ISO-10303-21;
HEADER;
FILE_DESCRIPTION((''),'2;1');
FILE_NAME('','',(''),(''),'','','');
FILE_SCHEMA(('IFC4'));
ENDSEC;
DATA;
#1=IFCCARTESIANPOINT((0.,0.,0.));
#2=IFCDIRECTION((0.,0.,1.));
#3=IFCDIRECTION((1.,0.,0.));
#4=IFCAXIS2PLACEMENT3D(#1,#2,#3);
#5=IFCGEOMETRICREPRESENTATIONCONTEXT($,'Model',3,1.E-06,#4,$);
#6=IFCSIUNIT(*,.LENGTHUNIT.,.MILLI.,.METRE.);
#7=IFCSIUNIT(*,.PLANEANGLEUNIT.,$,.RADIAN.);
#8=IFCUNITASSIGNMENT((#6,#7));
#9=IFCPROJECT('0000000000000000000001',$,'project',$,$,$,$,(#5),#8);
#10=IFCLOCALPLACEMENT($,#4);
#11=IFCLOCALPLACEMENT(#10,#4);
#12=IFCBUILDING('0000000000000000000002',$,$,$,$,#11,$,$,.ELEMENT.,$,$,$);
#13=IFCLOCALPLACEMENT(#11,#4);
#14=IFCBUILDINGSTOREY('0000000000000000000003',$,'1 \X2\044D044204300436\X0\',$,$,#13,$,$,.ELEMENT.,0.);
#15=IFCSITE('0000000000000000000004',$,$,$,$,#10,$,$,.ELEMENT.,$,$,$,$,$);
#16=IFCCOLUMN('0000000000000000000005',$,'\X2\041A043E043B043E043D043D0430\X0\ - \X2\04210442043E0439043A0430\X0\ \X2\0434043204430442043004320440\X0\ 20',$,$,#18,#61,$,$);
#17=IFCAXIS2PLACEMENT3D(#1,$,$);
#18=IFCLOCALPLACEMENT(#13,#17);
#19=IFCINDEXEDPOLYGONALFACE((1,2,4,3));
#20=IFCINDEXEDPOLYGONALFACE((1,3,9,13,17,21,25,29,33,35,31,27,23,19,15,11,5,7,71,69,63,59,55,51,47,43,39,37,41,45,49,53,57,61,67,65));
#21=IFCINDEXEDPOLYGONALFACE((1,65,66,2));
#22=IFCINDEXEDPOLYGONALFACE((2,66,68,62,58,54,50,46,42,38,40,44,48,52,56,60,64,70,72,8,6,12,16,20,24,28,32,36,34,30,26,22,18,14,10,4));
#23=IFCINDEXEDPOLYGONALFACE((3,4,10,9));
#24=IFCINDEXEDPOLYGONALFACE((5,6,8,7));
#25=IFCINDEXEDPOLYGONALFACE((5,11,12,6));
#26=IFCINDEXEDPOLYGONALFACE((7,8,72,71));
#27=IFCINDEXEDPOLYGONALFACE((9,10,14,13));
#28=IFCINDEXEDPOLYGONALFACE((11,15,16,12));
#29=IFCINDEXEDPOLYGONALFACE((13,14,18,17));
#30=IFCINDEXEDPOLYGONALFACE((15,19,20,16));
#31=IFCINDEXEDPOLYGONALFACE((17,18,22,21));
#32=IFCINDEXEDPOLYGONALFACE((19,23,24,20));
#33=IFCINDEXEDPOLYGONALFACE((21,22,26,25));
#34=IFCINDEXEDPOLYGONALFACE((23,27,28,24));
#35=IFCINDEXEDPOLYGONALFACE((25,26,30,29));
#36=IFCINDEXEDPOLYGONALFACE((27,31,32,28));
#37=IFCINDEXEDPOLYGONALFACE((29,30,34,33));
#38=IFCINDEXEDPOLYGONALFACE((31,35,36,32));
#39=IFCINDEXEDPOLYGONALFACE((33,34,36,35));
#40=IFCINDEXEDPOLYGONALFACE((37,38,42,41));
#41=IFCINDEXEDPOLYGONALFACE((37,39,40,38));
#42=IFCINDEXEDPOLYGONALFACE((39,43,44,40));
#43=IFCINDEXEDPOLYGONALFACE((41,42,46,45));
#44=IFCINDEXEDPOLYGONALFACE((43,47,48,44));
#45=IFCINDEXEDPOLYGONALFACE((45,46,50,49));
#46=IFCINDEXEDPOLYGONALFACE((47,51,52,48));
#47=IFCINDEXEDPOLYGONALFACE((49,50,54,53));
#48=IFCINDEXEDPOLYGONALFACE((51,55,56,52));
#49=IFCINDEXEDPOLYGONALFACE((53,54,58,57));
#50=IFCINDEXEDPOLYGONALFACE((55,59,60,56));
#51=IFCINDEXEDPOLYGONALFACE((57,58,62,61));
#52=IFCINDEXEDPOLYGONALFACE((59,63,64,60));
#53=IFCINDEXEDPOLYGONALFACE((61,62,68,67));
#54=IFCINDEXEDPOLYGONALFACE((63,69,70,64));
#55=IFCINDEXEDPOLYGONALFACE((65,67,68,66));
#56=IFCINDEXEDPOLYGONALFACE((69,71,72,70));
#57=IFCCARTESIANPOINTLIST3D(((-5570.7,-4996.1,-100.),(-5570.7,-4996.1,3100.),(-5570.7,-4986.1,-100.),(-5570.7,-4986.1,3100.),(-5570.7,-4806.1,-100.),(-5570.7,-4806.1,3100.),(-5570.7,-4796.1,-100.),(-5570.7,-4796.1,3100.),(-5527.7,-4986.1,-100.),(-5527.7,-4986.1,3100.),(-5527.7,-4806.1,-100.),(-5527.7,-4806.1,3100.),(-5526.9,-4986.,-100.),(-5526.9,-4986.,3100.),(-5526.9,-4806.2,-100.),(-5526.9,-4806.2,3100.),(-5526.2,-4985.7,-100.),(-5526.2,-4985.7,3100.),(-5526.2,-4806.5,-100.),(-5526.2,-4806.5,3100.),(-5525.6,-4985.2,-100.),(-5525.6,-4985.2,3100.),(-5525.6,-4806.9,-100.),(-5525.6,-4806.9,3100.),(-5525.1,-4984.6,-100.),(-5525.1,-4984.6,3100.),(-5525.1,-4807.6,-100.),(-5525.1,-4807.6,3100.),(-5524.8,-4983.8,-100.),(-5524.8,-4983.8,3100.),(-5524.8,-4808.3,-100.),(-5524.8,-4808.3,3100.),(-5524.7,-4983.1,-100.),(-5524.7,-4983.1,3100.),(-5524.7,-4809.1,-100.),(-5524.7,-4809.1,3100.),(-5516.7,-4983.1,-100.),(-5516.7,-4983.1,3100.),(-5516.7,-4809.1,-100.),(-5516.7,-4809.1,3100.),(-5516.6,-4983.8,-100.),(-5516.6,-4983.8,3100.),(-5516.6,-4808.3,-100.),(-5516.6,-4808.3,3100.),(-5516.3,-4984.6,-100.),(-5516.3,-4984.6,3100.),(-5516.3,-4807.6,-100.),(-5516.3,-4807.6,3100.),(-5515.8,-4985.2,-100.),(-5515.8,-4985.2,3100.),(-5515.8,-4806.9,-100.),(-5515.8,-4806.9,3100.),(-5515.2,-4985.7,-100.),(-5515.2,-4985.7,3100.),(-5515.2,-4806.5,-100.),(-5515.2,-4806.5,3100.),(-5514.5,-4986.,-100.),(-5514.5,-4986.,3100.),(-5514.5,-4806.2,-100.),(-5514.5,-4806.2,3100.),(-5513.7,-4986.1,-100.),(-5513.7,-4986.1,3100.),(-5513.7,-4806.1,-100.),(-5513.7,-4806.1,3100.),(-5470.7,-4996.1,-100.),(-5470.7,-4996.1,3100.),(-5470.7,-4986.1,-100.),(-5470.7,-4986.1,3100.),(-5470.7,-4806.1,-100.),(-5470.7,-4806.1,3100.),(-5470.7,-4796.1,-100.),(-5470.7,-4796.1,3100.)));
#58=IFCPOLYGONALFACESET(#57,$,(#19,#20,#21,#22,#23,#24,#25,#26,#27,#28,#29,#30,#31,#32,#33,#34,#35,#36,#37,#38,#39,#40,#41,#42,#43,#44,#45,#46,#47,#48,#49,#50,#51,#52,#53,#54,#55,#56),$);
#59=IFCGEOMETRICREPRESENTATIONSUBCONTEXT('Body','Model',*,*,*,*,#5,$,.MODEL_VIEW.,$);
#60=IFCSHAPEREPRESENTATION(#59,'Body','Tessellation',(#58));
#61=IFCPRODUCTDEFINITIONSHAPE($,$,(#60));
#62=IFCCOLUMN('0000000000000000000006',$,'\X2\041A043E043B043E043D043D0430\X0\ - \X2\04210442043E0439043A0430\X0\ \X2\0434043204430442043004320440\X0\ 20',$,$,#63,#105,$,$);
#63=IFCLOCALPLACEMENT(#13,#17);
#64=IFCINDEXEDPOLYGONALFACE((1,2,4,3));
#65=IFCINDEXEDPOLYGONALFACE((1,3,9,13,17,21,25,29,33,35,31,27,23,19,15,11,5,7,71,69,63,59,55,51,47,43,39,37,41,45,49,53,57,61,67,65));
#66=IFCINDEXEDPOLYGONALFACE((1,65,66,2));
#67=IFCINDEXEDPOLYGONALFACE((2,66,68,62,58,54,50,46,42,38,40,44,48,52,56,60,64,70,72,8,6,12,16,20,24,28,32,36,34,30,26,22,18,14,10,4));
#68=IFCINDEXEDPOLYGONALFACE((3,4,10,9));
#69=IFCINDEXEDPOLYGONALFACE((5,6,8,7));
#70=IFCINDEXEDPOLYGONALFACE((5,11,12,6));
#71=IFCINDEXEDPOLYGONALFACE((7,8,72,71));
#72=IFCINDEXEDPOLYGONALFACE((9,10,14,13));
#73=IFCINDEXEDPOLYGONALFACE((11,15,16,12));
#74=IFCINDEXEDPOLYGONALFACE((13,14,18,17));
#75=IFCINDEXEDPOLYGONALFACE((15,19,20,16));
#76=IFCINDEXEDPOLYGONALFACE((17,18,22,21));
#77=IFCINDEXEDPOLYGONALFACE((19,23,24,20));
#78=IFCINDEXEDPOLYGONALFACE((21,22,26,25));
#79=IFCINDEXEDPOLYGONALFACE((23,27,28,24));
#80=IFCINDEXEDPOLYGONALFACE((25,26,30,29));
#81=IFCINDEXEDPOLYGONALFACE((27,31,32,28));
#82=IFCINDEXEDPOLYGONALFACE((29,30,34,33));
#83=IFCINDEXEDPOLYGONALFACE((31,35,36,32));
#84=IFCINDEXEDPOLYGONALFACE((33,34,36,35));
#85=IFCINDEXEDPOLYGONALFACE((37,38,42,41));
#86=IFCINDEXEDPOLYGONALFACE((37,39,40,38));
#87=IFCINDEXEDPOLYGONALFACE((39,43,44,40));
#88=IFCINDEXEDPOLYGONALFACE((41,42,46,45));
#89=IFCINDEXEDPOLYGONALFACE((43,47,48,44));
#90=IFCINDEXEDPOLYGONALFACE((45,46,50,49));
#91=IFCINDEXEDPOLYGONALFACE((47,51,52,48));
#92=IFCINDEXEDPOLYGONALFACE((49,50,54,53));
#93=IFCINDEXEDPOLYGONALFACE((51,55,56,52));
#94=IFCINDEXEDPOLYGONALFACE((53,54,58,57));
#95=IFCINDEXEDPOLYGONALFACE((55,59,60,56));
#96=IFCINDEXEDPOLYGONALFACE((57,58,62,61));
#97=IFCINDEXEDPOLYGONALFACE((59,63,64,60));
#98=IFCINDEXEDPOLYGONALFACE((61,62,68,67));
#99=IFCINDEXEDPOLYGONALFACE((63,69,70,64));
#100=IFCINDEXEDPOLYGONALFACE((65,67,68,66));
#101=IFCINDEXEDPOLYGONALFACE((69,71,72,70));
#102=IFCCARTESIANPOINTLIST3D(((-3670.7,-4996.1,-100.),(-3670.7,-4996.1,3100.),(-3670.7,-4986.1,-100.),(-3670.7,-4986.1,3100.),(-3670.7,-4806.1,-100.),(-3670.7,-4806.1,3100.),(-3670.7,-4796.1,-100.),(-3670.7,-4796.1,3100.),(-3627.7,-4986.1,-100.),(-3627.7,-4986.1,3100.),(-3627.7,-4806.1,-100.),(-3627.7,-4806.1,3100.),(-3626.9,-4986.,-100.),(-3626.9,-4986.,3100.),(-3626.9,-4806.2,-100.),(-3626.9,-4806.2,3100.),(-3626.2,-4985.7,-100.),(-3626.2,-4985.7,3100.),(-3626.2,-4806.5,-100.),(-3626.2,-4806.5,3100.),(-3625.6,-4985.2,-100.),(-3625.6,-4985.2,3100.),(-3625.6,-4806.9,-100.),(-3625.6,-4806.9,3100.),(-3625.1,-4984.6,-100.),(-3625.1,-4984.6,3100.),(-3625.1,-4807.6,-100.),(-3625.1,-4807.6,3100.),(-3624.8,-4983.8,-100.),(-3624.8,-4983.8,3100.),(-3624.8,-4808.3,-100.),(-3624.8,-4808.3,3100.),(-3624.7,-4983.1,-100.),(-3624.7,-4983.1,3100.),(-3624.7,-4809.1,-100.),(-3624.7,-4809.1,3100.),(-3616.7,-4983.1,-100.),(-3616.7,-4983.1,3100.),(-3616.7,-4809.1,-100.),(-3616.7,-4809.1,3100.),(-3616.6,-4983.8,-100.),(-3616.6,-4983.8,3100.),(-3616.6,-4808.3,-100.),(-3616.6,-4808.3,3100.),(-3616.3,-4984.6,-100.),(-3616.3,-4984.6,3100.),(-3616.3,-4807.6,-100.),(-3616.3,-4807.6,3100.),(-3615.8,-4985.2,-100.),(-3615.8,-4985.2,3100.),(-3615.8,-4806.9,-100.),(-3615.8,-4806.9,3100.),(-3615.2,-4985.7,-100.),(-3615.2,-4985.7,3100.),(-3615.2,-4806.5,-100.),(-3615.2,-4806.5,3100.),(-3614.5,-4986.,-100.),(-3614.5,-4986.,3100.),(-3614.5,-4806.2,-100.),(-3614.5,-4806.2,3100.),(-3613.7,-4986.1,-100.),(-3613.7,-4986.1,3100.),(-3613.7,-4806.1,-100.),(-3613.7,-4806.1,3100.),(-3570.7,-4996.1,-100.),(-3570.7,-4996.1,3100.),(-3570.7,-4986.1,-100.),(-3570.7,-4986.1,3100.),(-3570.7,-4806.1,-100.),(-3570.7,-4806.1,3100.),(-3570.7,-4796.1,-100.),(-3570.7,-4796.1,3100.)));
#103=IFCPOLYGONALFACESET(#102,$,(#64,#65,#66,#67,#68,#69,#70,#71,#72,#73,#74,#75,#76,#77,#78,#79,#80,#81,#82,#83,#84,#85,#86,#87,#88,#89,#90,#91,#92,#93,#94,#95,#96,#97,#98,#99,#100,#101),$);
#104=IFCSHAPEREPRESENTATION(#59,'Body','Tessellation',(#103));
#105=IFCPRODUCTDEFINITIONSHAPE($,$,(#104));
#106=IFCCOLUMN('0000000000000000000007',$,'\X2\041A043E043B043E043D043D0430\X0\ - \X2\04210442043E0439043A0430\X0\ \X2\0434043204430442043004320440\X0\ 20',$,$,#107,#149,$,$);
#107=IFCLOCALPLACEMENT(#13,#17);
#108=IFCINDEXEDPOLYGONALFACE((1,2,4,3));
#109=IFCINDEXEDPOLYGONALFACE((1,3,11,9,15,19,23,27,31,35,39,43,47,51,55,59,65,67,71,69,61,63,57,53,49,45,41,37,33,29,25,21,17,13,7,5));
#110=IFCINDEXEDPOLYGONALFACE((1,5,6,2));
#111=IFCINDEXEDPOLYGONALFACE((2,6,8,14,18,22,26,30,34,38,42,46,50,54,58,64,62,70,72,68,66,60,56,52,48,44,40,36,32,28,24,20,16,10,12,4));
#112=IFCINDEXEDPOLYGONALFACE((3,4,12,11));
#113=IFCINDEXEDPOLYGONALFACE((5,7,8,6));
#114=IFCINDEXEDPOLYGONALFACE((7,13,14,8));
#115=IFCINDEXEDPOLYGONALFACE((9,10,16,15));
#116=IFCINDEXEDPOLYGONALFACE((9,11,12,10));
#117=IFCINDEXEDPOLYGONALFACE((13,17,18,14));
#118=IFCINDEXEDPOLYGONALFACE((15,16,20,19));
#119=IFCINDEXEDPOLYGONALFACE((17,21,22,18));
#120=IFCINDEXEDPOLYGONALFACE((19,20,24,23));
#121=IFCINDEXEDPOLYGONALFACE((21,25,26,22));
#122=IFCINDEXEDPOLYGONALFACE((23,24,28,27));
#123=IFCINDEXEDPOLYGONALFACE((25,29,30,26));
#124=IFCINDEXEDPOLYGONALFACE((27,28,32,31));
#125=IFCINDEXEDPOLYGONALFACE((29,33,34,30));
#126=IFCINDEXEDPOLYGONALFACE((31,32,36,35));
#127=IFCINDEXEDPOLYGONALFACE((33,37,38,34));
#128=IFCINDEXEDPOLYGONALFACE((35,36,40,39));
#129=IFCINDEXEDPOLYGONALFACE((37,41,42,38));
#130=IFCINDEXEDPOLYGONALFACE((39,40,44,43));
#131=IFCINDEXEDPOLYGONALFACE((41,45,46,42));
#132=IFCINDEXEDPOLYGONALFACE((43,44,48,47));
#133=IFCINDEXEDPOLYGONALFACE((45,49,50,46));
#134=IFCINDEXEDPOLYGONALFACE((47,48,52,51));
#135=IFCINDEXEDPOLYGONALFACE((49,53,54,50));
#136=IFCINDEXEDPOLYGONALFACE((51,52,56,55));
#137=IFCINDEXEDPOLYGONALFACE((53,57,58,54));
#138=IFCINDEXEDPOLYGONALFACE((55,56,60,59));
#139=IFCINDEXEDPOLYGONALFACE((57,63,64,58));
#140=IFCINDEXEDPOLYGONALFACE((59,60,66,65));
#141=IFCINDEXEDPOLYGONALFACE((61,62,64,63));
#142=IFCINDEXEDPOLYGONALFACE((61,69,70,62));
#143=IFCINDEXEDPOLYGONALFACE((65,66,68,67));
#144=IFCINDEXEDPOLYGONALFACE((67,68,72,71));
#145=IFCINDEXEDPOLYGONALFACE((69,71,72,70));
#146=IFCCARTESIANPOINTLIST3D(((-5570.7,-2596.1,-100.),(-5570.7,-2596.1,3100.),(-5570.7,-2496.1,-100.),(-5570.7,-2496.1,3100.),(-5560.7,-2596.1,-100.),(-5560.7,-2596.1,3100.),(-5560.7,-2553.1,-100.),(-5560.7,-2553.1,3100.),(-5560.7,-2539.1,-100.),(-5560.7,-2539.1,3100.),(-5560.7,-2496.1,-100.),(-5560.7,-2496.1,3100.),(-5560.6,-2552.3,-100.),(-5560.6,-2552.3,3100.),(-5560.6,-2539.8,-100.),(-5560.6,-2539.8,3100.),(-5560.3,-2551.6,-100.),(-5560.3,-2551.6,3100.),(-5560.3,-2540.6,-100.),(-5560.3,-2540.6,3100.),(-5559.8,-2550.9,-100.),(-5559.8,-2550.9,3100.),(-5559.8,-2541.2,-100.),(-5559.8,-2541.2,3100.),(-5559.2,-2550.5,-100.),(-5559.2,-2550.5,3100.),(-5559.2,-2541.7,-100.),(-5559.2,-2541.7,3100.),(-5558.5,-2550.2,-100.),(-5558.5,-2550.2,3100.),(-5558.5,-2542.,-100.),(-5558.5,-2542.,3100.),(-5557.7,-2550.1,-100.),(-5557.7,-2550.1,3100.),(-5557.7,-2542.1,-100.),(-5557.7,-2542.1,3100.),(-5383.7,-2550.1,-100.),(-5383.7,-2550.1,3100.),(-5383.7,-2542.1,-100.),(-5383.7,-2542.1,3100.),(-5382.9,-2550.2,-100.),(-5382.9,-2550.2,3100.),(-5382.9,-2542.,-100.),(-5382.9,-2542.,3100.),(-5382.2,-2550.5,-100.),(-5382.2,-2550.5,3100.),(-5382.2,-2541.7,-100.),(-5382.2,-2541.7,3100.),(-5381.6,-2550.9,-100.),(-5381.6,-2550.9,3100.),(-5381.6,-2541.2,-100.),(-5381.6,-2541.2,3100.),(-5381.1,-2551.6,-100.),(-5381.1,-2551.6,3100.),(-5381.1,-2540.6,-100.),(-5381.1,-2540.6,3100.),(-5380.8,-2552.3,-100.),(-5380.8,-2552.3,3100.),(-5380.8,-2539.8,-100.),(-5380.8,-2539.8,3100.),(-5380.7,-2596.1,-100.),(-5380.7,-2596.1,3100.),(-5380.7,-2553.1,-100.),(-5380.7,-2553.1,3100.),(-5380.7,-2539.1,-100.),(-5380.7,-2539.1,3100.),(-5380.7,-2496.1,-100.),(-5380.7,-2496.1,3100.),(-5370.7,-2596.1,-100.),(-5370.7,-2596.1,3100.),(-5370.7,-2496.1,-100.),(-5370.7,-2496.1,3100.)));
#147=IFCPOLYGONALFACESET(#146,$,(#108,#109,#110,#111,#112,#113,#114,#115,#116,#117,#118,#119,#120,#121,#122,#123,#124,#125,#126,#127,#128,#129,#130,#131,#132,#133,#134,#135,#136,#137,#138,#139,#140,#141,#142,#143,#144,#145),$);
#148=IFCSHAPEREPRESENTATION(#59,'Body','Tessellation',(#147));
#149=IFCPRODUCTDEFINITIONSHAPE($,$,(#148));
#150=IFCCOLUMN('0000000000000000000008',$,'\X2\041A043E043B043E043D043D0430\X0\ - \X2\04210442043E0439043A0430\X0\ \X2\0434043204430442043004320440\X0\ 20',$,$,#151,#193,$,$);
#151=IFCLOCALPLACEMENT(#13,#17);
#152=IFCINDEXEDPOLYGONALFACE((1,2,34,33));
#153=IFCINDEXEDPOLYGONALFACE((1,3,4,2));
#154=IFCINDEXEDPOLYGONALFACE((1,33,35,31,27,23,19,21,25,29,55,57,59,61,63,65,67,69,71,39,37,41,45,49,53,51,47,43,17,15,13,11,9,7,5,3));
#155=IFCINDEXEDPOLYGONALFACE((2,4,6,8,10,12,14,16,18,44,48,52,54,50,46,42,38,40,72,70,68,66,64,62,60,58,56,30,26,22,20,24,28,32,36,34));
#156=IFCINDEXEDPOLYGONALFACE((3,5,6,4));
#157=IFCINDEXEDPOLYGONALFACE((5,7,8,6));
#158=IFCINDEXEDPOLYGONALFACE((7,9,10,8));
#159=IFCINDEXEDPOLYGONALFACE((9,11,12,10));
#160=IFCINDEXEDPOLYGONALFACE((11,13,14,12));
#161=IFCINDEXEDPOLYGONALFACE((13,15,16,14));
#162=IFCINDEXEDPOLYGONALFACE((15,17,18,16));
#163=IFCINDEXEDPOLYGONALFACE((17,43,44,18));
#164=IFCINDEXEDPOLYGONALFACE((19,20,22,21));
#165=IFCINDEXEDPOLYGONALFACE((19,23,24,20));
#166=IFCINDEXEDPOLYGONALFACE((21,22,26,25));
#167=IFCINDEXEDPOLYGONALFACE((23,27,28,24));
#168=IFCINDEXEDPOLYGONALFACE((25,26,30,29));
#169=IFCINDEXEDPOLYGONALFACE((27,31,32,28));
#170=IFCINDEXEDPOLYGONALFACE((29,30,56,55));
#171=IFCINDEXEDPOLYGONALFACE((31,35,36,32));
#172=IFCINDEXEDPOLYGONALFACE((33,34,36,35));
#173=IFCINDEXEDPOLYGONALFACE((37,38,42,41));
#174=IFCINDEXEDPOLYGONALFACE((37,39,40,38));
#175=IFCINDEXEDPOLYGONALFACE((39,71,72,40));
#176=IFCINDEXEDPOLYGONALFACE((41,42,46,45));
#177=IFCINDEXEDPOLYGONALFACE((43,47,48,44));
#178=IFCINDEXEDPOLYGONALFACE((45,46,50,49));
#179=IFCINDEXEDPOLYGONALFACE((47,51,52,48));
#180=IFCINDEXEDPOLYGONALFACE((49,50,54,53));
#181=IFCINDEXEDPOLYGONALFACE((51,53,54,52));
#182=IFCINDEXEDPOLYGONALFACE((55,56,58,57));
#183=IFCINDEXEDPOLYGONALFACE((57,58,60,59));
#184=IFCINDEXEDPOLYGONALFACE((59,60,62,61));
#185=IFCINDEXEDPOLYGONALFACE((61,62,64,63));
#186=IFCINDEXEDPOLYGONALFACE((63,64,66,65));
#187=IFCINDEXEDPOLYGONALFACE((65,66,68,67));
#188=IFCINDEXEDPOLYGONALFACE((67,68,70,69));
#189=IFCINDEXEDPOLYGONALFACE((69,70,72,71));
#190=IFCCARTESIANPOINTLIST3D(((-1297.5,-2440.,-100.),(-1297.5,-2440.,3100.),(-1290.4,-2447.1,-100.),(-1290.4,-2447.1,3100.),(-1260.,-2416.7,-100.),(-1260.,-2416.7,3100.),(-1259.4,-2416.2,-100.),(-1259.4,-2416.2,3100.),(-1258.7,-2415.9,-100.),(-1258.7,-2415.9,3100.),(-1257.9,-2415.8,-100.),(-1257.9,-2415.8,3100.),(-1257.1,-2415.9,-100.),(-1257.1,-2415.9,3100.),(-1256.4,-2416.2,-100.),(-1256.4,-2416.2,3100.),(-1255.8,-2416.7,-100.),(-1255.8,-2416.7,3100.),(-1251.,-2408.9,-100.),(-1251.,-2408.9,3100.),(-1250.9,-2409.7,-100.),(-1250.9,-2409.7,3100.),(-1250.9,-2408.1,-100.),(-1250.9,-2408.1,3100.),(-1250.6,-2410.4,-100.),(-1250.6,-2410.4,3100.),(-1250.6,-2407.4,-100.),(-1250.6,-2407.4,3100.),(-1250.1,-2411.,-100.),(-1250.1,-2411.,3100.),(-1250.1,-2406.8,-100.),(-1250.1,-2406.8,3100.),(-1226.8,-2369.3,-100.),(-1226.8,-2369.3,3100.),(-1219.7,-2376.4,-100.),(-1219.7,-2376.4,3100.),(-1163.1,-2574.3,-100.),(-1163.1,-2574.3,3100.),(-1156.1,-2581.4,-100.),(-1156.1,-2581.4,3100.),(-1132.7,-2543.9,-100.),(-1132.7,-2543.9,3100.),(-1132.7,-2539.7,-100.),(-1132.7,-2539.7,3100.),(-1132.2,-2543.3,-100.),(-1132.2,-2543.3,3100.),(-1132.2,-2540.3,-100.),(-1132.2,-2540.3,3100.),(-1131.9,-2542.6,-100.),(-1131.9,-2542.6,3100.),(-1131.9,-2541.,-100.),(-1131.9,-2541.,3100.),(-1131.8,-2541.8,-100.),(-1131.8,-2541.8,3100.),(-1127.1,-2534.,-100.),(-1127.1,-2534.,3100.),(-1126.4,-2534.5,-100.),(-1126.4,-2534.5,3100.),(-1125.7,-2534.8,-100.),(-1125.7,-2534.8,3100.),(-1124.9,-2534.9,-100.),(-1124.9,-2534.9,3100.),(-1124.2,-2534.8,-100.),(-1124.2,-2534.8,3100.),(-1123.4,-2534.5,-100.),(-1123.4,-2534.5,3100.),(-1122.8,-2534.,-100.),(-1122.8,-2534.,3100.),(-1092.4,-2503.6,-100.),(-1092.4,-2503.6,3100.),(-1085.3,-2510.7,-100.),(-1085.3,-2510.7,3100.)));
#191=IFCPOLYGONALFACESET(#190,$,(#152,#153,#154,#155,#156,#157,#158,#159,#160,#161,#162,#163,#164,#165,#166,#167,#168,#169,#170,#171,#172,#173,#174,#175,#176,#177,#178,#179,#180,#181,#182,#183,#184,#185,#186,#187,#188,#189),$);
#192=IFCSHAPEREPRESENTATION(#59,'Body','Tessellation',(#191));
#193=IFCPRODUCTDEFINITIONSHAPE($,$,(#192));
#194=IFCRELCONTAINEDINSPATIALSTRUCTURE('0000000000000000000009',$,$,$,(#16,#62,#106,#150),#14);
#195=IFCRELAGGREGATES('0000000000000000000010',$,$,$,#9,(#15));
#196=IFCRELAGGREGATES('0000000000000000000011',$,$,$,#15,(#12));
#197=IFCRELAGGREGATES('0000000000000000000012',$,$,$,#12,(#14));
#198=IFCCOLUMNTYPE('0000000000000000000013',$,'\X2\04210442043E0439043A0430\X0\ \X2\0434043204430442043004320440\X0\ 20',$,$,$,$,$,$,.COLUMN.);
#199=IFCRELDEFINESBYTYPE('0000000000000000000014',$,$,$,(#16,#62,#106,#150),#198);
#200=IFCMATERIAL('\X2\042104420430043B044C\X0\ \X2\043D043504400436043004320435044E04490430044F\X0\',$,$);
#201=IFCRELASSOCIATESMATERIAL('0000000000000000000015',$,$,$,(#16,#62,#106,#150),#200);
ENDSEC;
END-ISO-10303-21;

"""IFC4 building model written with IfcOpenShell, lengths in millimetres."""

from ifc_helpers import new_model, si_unit, frame, origin_with_axes, place, context, subcontext, project, spatial, line, arc, indexed_curve, outline, extrude, source, transform, mapped, material, type_object, element, save


model = new_model("IFC4")

# Units and contexts
model_context = context("Model", 3, precision=1e-06, world=origin_with_axes())
body_context = subcontext(model_context, "Body", "Model", "MODEL_VIEW")
ifc_project = project(units=[si_unit("LENGTHUNIT", "METRE", prefix="MILLI"), si_unit("PLANEANGLEUNIT", "RADIAN")], contexts=[model_context])

# Site, building, storey
site_placement = place(None, origin_with_axes())
site = spatial("IfcSite", under=ifc_project, at=site_placement, CompositionType="ELEMENT")
building_placement = place(site_placement, origin_with_axes())
building = spatial("IfcBuilding", under=site, at=building_placement, CompositionType="ELEMENT")
storey_placement = place(building_placement, origin_with_axes())
storey = spatial("IfcBuildingStorey", under=building, at=storey_placement, Name="1 этаж", CompositionType="ELEMENT", Elevation=0.0)

# Columns
ifc_material_1 = material(Name="Сталь нержавеющая")
column_type = type_object("IfcColumnType", Name="Стойка двутавр 20", PredefinedType="COLUMN")
shared_shape_1 = source(origin_with_axes(), body_context, "Body", "SweptSolid", [
    extrude(outline(indexed_curve([(-50.0, -100.0), (50.0, -100.0), (50.0, -90.0), (7.0, -90.0), (4.9, -89.1), (4.0, -87.0), (4.0, 87.0), (4.9, 89.1), (7.0, 90.0), (50.0, 90.0), (50.0, 100.0), (-50.0, 100.0), (-50.0, 90.0), (-7.0, 90.0), (-4.9, 89.1), (-4.0, 87.0), (-4.0, -87.0), (-4.9, -89.1), (-7.0, -90.0), (-50.0, -90.0)], segments=[line(1, 2), line(2, 3), line(3, 4), arc(4, 5, 6), line(6, 7), arc(7, 8, 9), line(9, 10), line(10, 11), line(11, 12), line(12, 13), line(13, 14), arc(14, 15, 16), line(16, 17), arc(17, 18, 19), line(19, 20), line(20, 1)])), origin_with_axes(), (0.0, 0.0, 1.0), 3200.0),
])
for number, where, z_axis, x_axis, name in (
    (1, (-5520.7, -4896.1, -100.0), (0.0, 0.0, 1.0), (1.0, 0.0, 0.0), "Колонна - Стойка двутавр 20"),
    (2, (-3620.7, -4896.1, -100.0), (0.0, 0.0, 1.0), (1.0, 0.0, 0.0), "Колонна - Стойка двутавр 20"),
    (3, (-5470.7, -2546.1, -100.0), (0.0, 0.0, 1.0), (0.0, 1.0, 0.0), "Колонна - Стойка двутавр 20"),
    (4, (-1191.4, -2475.3, -100.0), (0.0, 0.0, 1.0), (0.707107, 0.707107, 0.0), "Колонна - Стойка двутавр 20"),
):
    element("IfcColumn", number, at=place(storey_placement, frame(where, z_axis=z_axis, x_axis=x_axis)), inside=storey, type_object=column_type, material=ifc_material_1, Name=name, context=body_context, shape_type="MappedRepresentation", body=[
        mapped(shared_shape_1, transform((0.0, 0.0, 0.0), x_axis=(1.0, 0.0, 0.0), y_axis=(0.0, 1.0, 0.0), z_axis=(0.0, 0.0, 1.0), scale=1.0)),
    ])

save(model, "model.ifc")
